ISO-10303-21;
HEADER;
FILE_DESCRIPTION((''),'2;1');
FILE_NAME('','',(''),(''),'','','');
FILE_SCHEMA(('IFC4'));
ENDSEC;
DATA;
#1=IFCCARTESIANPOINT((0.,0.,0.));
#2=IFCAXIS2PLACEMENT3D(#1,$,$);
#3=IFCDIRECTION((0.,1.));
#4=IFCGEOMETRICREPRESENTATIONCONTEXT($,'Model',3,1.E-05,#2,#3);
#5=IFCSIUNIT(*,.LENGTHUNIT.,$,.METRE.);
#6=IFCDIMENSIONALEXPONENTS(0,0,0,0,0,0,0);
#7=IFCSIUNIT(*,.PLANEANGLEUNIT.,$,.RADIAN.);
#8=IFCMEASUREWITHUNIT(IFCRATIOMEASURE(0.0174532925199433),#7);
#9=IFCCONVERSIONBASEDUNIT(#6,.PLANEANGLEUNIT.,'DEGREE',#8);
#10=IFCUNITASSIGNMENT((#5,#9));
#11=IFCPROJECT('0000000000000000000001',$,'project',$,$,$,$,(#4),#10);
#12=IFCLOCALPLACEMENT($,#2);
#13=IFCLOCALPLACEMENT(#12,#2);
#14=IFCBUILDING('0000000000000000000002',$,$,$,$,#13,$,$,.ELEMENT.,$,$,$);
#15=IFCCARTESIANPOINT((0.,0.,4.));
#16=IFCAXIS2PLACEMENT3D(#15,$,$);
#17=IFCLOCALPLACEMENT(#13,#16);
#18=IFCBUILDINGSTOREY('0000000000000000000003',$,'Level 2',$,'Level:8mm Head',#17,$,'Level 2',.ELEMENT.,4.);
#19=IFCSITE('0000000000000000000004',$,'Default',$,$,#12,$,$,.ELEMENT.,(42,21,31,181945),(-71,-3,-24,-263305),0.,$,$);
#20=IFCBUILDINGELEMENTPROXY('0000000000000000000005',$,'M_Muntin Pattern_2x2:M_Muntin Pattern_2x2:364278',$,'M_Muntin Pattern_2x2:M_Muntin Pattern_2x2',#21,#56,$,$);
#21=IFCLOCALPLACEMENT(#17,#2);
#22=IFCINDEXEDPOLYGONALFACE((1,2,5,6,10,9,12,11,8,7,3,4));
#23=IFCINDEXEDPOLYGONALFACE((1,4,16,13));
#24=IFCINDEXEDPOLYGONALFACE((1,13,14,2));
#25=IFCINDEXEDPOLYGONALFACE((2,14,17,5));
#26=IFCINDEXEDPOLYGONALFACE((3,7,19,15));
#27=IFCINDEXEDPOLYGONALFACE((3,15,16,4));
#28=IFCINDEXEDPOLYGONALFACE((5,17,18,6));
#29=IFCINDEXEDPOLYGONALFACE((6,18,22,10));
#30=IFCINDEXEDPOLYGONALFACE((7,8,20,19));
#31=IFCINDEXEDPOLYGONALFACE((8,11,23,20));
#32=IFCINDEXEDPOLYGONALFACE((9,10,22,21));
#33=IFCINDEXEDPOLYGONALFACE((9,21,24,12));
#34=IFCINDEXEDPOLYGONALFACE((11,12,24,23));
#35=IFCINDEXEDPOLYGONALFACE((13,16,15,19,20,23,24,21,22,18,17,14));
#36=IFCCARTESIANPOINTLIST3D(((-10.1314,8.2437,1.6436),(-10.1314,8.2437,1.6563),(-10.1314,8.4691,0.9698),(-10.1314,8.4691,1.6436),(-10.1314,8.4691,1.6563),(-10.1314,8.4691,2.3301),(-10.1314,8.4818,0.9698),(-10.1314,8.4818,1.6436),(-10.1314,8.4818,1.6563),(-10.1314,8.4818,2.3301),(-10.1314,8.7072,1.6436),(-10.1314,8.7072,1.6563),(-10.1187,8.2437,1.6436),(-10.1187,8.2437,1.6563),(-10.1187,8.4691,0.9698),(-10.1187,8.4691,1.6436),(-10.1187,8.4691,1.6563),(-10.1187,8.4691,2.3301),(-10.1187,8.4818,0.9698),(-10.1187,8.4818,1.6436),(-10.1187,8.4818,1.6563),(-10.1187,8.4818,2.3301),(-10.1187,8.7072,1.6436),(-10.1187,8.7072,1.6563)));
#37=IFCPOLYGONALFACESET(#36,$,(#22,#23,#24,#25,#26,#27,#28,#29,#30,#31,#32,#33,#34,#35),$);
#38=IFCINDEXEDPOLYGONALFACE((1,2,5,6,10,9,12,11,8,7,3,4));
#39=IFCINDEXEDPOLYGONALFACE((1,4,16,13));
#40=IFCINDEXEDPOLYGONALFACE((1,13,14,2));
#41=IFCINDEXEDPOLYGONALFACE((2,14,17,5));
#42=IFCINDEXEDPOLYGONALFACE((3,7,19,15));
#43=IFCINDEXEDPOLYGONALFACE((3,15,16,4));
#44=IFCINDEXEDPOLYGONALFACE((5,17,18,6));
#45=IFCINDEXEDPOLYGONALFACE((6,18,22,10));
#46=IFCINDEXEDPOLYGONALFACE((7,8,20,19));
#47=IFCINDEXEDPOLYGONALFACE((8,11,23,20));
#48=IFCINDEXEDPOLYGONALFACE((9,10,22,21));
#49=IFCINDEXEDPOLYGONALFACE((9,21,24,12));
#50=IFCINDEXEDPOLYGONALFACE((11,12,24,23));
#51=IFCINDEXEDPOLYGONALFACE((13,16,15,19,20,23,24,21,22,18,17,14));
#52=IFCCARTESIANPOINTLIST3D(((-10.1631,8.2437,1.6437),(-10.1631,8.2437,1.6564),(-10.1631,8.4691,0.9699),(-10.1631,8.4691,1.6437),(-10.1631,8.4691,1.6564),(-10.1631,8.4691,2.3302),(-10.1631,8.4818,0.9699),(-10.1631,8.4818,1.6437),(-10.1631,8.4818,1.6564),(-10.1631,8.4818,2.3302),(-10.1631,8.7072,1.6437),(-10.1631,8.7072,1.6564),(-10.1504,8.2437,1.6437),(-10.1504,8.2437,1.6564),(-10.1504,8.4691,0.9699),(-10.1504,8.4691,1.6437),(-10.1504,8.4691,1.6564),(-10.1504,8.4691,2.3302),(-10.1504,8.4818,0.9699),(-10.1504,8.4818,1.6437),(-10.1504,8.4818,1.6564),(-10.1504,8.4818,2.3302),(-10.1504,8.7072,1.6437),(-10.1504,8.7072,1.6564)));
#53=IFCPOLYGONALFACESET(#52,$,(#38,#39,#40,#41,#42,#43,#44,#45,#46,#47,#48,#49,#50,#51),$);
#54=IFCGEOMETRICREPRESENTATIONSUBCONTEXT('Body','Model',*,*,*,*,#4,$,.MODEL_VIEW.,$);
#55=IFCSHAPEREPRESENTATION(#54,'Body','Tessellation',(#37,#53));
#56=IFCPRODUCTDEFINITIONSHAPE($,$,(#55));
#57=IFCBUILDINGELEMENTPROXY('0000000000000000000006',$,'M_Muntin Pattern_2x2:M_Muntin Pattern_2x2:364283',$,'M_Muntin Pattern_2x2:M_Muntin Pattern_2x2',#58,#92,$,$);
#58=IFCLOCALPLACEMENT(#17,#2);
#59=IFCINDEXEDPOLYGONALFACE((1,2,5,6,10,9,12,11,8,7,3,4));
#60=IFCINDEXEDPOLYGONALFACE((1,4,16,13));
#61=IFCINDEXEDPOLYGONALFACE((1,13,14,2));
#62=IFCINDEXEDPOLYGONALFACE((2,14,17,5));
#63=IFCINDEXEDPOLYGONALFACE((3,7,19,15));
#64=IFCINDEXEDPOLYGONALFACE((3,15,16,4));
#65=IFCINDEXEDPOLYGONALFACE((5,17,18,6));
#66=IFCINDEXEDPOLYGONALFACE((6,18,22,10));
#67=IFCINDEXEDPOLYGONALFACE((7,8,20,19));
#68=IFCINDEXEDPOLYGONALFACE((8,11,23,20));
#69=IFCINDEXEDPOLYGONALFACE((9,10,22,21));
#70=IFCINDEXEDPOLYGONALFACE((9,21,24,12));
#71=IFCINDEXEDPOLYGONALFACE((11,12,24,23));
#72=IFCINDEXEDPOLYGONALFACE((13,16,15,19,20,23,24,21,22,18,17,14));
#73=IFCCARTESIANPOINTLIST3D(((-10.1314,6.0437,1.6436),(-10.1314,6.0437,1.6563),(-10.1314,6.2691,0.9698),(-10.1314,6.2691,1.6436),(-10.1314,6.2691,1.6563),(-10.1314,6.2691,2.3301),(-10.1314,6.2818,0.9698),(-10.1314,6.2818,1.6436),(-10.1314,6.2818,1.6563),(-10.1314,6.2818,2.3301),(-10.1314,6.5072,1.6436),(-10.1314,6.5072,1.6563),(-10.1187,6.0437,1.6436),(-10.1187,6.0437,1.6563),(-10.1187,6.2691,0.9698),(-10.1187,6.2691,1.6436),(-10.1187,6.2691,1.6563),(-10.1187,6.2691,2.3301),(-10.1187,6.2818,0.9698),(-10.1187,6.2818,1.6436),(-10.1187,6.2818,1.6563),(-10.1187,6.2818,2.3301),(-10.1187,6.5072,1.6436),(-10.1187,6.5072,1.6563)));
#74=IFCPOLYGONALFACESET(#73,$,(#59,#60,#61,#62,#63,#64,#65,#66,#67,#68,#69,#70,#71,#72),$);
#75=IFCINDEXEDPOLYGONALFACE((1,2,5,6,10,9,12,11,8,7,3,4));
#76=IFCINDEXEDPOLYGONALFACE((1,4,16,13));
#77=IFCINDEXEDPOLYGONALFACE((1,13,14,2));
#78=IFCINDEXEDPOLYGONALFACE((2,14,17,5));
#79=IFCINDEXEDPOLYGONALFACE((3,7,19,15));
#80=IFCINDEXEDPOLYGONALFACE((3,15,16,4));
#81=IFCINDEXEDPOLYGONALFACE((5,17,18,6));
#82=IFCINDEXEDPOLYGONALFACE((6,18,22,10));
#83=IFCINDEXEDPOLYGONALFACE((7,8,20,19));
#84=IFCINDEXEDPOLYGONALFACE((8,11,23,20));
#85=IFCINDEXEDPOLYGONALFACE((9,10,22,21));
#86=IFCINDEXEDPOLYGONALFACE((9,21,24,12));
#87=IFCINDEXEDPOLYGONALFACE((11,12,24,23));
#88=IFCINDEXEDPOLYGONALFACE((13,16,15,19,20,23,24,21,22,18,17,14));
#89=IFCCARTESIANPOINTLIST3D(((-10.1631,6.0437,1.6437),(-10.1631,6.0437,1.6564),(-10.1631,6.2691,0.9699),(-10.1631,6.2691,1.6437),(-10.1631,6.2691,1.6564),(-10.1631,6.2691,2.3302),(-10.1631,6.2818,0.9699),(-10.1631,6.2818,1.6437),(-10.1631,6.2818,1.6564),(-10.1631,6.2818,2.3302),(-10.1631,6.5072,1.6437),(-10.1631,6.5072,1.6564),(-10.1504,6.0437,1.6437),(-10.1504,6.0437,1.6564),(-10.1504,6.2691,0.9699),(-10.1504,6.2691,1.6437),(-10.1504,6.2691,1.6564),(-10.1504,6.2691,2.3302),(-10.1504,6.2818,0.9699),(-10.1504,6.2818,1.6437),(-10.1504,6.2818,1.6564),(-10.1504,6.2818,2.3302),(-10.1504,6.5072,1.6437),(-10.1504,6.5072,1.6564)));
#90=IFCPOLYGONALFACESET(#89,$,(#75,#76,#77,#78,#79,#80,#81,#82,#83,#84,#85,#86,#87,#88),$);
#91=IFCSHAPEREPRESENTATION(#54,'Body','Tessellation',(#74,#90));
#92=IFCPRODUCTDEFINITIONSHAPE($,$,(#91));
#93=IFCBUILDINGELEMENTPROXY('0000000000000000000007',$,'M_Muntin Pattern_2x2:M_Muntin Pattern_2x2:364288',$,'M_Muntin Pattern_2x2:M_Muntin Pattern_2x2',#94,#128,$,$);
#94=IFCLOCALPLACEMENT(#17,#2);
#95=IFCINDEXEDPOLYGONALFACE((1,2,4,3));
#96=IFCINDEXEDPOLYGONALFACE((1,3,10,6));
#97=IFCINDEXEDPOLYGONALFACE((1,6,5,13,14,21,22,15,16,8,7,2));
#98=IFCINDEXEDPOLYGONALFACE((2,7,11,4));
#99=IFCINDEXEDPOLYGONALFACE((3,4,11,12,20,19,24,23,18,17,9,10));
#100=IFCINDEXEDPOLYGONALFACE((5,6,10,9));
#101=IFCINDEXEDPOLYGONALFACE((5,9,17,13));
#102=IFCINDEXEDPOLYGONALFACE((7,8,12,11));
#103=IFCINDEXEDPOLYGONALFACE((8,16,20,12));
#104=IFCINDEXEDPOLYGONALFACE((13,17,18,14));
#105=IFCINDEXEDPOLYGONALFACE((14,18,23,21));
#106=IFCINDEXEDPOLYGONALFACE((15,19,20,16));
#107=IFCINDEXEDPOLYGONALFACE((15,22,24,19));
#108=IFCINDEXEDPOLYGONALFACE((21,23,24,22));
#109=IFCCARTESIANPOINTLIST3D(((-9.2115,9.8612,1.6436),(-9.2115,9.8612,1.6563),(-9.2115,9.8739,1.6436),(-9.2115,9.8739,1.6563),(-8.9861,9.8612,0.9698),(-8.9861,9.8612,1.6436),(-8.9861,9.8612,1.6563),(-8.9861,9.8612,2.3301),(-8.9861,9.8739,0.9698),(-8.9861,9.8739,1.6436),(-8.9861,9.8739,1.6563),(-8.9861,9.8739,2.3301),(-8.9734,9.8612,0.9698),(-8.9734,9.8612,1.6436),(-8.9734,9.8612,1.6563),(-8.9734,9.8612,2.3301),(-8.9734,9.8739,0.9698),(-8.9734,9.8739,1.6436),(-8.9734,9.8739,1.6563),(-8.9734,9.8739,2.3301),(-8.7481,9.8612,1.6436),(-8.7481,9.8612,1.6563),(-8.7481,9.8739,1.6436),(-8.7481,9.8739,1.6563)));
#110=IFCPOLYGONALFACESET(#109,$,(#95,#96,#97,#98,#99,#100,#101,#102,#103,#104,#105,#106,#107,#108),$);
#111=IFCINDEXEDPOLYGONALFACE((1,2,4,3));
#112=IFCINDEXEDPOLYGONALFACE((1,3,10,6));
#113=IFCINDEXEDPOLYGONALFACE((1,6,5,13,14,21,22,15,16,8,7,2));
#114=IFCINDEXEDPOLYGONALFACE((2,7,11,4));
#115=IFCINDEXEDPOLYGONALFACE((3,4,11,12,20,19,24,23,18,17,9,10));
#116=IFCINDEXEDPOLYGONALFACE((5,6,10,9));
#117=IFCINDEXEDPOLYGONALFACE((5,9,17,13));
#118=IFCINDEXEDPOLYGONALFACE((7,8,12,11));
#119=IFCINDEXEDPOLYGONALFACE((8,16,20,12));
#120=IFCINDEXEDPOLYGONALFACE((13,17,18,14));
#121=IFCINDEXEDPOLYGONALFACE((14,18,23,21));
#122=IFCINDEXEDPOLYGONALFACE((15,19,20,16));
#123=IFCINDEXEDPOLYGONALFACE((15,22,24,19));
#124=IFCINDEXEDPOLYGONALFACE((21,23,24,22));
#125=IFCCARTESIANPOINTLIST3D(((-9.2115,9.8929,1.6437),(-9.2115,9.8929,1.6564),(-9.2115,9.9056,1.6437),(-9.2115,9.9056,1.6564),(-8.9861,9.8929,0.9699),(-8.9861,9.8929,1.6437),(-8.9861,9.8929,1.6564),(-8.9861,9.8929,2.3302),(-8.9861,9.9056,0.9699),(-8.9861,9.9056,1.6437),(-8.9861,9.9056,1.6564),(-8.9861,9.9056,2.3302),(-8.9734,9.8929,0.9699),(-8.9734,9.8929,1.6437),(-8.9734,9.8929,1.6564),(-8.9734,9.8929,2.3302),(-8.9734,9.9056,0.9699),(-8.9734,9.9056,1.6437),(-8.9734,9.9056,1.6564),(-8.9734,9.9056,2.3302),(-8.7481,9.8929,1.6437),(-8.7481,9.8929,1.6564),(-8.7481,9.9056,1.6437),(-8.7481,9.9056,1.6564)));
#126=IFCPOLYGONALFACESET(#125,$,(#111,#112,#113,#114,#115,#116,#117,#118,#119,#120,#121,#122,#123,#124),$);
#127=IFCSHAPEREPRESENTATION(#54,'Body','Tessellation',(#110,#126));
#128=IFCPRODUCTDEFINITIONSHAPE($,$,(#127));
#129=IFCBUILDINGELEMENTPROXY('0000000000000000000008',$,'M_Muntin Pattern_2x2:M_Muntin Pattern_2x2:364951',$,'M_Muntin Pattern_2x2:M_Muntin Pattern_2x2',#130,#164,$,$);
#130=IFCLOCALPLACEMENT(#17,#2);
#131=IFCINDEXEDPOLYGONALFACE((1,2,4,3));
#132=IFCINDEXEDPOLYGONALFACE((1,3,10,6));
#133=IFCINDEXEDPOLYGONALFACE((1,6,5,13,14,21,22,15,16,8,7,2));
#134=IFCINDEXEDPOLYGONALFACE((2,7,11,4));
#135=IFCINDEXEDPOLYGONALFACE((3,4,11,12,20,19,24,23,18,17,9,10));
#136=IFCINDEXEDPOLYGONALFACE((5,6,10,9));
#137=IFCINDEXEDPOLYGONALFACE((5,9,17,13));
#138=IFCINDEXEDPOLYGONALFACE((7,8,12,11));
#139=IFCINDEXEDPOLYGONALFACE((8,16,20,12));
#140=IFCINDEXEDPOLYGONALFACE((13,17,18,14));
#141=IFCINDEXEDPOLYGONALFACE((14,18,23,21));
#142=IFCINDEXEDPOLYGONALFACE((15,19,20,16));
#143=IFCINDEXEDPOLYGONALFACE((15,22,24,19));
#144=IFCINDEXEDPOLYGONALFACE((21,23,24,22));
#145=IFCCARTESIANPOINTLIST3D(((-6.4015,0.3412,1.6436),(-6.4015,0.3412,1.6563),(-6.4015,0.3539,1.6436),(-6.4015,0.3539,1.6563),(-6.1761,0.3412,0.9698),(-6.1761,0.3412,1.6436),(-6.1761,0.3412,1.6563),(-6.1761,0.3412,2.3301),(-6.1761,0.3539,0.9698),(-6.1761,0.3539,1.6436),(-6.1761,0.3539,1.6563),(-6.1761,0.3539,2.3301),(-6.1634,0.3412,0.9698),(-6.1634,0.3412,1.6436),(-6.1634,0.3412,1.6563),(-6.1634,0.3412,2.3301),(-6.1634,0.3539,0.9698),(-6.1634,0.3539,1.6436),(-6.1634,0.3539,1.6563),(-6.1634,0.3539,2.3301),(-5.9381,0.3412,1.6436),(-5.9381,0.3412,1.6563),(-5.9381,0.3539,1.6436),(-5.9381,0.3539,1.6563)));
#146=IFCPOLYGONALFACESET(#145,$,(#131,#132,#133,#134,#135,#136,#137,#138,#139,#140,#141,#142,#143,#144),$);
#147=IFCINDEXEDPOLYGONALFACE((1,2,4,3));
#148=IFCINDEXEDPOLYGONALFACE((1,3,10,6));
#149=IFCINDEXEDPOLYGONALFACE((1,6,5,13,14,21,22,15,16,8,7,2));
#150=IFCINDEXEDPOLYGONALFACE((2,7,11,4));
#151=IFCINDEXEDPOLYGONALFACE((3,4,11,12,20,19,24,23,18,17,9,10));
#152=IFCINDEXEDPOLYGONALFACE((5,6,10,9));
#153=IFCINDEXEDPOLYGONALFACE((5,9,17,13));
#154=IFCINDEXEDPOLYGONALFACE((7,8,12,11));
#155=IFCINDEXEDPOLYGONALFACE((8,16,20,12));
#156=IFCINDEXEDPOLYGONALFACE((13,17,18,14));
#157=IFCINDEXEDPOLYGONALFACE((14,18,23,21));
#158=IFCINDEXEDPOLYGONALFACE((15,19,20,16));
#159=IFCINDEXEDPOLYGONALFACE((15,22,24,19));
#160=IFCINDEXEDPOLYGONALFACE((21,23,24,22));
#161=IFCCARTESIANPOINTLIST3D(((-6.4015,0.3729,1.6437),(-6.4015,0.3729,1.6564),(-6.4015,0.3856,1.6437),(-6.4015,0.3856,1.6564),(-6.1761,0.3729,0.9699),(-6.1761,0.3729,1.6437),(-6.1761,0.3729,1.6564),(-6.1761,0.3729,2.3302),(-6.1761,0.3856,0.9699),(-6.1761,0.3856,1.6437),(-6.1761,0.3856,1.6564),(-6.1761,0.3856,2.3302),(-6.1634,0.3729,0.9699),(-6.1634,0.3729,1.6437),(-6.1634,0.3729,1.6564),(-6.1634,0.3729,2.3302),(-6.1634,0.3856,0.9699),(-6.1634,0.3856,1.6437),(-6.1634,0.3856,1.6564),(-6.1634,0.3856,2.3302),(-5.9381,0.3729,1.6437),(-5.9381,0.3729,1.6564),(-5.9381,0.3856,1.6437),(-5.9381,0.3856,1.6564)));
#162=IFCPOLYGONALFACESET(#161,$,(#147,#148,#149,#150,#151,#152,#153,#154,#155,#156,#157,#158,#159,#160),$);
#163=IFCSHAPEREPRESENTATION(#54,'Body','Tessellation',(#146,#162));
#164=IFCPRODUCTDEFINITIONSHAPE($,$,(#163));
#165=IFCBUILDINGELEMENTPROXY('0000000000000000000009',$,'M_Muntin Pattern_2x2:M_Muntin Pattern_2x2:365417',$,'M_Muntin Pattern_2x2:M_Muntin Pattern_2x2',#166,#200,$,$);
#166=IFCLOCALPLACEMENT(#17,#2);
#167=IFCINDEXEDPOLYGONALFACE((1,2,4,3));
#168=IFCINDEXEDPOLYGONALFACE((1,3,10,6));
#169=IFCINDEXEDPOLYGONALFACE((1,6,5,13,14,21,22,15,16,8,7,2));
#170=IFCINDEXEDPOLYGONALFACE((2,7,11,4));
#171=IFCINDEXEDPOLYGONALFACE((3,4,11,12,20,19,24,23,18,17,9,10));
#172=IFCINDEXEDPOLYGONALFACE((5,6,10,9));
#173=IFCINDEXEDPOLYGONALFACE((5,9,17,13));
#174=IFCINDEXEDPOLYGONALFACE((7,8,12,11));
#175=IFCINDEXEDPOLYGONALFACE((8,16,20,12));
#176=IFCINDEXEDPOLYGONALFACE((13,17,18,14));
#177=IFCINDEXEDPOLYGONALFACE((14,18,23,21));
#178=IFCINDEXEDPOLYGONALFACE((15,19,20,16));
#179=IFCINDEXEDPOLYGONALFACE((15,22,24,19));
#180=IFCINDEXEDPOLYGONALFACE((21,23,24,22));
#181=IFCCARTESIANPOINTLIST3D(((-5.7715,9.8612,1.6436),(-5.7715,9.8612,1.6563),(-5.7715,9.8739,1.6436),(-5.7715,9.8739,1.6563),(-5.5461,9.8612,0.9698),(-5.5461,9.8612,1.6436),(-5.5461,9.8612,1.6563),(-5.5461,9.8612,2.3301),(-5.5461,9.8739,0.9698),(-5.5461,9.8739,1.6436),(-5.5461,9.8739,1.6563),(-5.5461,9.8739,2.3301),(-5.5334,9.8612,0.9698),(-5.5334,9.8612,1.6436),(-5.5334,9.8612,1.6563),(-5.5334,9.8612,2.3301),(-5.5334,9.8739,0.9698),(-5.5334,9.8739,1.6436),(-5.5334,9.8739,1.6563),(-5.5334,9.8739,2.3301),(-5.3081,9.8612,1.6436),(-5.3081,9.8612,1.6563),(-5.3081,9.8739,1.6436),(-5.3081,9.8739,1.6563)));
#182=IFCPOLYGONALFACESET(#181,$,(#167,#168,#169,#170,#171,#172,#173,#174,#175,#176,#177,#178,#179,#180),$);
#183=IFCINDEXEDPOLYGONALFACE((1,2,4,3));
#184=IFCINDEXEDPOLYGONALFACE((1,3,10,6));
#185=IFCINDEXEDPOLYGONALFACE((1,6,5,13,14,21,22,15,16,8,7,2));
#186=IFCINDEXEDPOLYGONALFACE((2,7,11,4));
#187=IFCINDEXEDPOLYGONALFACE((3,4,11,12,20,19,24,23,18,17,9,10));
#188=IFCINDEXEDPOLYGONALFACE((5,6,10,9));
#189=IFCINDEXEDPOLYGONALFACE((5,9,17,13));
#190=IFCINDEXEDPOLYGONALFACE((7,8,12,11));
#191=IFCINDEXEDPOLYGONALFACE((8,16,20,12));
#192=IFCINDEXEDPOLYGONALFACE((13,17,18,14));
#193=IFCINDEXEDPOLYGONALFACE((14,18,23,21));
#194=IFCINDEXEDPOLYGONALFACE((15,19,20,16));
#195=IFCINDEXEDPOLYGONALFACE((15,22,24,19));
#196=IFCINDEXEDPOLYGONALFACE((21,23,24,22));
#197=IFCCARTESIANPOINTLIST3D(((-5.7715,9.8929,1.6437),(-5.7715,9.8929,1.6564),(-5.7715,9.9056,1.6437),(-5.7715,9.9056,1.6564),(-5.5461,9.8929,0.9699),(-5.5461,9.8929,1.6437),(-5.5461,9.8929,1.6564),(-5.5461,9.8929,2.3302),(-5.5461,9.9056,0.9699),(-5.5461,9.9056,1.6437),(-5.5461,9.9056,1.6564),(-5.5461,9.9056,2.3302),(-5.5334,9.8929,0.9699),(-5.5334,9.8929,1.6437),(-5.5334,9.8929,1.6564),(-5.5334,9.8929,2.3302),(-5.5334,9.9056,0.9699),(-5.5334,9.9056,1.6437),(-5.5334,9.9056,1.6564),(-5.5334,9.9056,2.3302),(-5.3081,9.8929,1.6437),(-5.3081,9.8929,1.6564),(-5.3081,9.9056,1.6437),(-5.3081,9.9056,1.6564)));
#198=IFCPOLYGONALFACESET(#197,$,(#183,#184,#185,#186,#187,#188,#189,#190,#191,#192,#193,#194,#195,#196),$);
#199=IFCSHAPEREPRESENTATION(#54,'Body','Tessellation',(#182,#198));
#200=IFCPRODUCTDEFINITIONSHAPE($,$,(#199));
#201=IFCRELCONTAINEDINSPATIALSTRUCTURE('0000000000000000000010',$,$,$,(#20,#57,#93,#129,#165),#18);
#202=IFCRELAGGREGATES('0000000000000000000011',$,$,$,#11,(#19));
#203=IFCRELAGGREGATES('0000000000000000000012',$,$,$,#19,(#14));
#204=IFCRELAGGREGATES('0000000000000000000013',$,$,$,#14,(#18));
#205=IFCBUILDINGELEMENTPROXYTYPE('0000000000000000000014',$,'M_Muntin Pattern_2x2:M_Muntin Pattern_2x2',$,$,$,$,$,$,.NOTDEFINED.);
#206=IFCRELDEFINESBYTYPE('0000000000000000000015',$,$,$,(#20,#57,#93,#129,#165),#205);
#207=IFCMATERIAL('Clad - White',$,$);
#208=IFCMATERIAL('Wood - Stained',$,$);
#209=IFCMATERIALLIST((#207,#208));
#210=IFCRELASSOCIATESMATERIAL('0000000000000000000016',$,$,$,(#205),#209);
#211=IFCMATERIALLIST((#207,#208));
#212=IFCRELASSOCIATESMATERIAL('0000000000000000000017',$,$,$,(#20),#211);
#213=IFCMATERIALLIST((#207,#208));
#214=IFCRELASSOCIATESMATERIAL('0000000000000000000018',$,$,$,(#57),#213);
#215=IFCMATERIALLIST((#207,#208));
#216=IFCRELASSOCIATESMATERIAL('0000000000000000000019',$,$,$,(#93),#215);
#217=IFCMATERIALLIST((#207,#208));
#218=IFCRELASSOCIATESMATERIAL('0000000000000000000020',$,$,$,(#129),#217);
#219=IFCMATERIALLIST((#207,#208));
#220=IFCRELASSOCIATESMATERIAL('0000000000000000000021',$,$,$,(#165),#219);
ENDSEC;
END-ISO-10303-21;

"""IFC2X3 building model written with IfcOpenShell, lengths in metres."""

from ifc_helpers import new_model, entity, si_unit, converted_unit, direction, frame, origin, place, context, subcontext, project, spatial, polyline, outline, extrude, source, transform, mapped, material, material_list, type_object, type_shapes, element, save


model = new_model("IFC2X3")

# Units and contexts
model_context = context("Model", 3, precision=1e-05, world=origin(), true_north=direction((0.0, 1.0)))
body_context = subcontext(model_context, "Body", "Model", "MODEL_VIEW")
ifc_project = project(units=[si_unit("LENGTHUNIT", "METRE"), converted_unit("PLANEANGLEUNIT", "DEGREE", entity("IfcRatioMeasure", 0.0174532925199433), si_unit("PLANEANGLEUNIT", "RADIAN"), dimensions=[0, 0, 0, 0, 0, 0, 0])], contexts=[model_context])

# Site, building, storey
site_placement = place(None, origin())
site = spatial("IfcSite", under=ifc_project, at=site_placement, Name="Default", CompositionType="ELEMENT", RefLatitude=(42, 21, 31, 181945), RefLongitude=(-71, -3, -24, -263305), RefElevation=0.0)
building_placement = place(site_placement, origin())
building = spatial("IfcBuilding", under=site, at=building_placement, CompositionType="ELEMENT")
storey_placement = place(building_placement, frame((0.0, 0.0, 4.0)))
storey = spatial("IfcBuildingStorey", under=building, at=storey_placement, Name="Level 2", ObjectType="Level:8mm Head", LongName="Level 2", CompositionType="ELEMENT", Elevation=4.0)

# Building element proxies
ifc_material_1 = material(Name="Clad - White")
ifc_material_2 = material(Name="Wood - Stained")
ifc_material_list_1 = material_list([ifc_material_1, ifc_material_2])
ifc_material_list_2 = material_list([ifc_material_1, ifc_material_2])
building_element_proxy_type_1 = type_object("IfcBuildingElementProxyType", Name="M_Muntin Pattern_2x2:M_Muntin Pattern_2x2", PredefinedType="NOTDEFINED", material=ifc_material_list_2)
shared_shape_1 = source(origin(), body_context, "Body", "SweptSolid", [
    extrude(outline(polyline([(0.0064, -0.0064), (0.6801, -0.0064), (0.6801, 0.0063), (0.0064, 0.0063), (0.0064, 0.2317), (-0.0063, 0.2317), (-0.0063, 0.0063), (-0.6802, 0.0063), (-0.6802, -0.0064), (-0.0063, -0.0064), (-0.0063, -0.2317), (0.0064, -0.2317), (0.0064, -0.0064)])), frame((0.0, -0.0222, 0.6801), z_axis=(0.0, 1.0, 0.0), x_axis=(0.0, 0.0, 1.0)), (0.0, 0.0, 1.0), 0.0127),
    extrude(outline(polyline([(0.0064, -0.0064), (0.6802, -0.0064), (0.6802, 0.0063), (0.0064, 0.0063), (0.0064, 0.2317), (-0.0063, 0.2317), (-0.0063, 0.0063), (-0.6802, 0.0063), (-0.6802, -0.0064), (-0.0063, -0.0064), (-0.0063, -0.2317), (0.0064, -0.2317), (0.0064, -0.0064)])), frame((0.0, 0.0095, 0.6802), z_axis=(0.0, 1.0, 0.0), x_axis=(0.0, 0.0, 1.0)), (0.0, 0.0, 1.0), 0.0127),
])
type_shapes(building_element_proxy_type_1, [shared_shape_1])
proxy_1_placement = place(storey_placement, frame((-10.1409, 8.4754, 0.9699), z_axis=(0.0, 0.0, 1.0), x_axis=(0.0, 1.0, 0.0)))
element("IfcBuildingElementProxy", 1, at=proxy_1_placement, inside=storey, type_object=building_element_proxy_type_1, material=ifc_material_list_1, Name="M_Muntin Pattern_2x2:M_Muntin Pattern_2x2:364278", ObjectType="M_Muntin Pattern_2x2:M_Muntin Pattern_2x2", context=body_context, shape_type="MappedRepresentation", body=[
    mapped(shared_shape_1, transform((0.0, 0.0, 0.0), scale=1.0)),
])
ifc_material_list_3 = material_list([ifc_material_1, ifc_material_2])
proxy_2_placement = place(storey_placement, frame((-10.1409, 6.2754, 0.9699), z_axis=(0.0, 0.0, 1.0), x_axis=(0.0, 1.0, 0.0)))
element("IfcBuildingElementProxy", 2, at=proxy_2_placement, inside=storey, type_object=building_element_proxy_type_1, material=ifc_material_list_3, Name="M_Muntin Pattern_2x2:M_Muntin Pattern_2x2:364283", ObjectType="M_Muntin Pattern_2x2:M_Muntin Pattern_2x2", context=body_context, shape_type="MappedRepresentation", body=[
    mapped(shared_shape_1, transform((0.0, 0.0, 0.0), scale=1.0)),
])
ifc_material_list_4 = material_list([ifc_material_1, ifc_material_2])
proxy_3_placement = place(storey_placement, frame((-8.9798, 9.8834, 0.9699)))
element("IfcBuildingElementProxy", 3, at=proxy_3_placement, inside=storey, type_object=building_element_proxy_type_1, material=ifc_material_list_4, Name="M_Muntin Pattern_2x2:M_Muntin Pattern_2x2:364288", ObjectType="M_Muntin Pattern_2x2:M_Muntin Pattern_2x2", context=body_context, shape_type="MappedRepresentation", body=[
    mapped(shared_shape_1, transform((0.0, 0.0, 0.0), scale=1.0)),
])
ifc_material_list_5 = material_list([ifc_material_1, ifc_material_2])
proxy_4_placement = place(storey_placement, frame((-6.1698, 0.3634, 0.9699)))
element("IfcBuildingElementProxy", 4, at=proxy_4_placement, inside=storey, type_object=building_element_proxy_type_1, material=ifc_material_list_5, Name="M_Muntin Pattern_2x2:M_Muntin Pattern_2x2:364951", ObjectType="M_Muntin Pattern_2x2:M_Muntin Pattern_2x2", context=body_context, shape_type="MappedRepresentation", body=[
    mapped(shared_shape_1, transform((0.0, 0.0, 0.0), scale=1.0)),
])
ifc_material_list_6 = material_list([ifc_material_1, ifc_material_2])
proxy_5_placement = place(storey_placement, frame((-5.5398, 9.8834, 0.9699)))
element("IfcBuildingElementProxy", 5, at=proxy_5_placement, inside=storey, type_object=building_element_proxy_type_1, material=ifc_material_list_6, Name="M_Muntin Pattern_2x2:M_Muntin Pattern_2x2:365417", ObjectType="M_Muntin Pattern_2x2:M_Muntin Pattern_2x2", context=body_context, shape_type="MappedRepresentation", body=[
    mapped(shared_shape_1, transform((0.0, 0.0, 0.0), scale=1.0)),
])

save(model, "model.ifc")
